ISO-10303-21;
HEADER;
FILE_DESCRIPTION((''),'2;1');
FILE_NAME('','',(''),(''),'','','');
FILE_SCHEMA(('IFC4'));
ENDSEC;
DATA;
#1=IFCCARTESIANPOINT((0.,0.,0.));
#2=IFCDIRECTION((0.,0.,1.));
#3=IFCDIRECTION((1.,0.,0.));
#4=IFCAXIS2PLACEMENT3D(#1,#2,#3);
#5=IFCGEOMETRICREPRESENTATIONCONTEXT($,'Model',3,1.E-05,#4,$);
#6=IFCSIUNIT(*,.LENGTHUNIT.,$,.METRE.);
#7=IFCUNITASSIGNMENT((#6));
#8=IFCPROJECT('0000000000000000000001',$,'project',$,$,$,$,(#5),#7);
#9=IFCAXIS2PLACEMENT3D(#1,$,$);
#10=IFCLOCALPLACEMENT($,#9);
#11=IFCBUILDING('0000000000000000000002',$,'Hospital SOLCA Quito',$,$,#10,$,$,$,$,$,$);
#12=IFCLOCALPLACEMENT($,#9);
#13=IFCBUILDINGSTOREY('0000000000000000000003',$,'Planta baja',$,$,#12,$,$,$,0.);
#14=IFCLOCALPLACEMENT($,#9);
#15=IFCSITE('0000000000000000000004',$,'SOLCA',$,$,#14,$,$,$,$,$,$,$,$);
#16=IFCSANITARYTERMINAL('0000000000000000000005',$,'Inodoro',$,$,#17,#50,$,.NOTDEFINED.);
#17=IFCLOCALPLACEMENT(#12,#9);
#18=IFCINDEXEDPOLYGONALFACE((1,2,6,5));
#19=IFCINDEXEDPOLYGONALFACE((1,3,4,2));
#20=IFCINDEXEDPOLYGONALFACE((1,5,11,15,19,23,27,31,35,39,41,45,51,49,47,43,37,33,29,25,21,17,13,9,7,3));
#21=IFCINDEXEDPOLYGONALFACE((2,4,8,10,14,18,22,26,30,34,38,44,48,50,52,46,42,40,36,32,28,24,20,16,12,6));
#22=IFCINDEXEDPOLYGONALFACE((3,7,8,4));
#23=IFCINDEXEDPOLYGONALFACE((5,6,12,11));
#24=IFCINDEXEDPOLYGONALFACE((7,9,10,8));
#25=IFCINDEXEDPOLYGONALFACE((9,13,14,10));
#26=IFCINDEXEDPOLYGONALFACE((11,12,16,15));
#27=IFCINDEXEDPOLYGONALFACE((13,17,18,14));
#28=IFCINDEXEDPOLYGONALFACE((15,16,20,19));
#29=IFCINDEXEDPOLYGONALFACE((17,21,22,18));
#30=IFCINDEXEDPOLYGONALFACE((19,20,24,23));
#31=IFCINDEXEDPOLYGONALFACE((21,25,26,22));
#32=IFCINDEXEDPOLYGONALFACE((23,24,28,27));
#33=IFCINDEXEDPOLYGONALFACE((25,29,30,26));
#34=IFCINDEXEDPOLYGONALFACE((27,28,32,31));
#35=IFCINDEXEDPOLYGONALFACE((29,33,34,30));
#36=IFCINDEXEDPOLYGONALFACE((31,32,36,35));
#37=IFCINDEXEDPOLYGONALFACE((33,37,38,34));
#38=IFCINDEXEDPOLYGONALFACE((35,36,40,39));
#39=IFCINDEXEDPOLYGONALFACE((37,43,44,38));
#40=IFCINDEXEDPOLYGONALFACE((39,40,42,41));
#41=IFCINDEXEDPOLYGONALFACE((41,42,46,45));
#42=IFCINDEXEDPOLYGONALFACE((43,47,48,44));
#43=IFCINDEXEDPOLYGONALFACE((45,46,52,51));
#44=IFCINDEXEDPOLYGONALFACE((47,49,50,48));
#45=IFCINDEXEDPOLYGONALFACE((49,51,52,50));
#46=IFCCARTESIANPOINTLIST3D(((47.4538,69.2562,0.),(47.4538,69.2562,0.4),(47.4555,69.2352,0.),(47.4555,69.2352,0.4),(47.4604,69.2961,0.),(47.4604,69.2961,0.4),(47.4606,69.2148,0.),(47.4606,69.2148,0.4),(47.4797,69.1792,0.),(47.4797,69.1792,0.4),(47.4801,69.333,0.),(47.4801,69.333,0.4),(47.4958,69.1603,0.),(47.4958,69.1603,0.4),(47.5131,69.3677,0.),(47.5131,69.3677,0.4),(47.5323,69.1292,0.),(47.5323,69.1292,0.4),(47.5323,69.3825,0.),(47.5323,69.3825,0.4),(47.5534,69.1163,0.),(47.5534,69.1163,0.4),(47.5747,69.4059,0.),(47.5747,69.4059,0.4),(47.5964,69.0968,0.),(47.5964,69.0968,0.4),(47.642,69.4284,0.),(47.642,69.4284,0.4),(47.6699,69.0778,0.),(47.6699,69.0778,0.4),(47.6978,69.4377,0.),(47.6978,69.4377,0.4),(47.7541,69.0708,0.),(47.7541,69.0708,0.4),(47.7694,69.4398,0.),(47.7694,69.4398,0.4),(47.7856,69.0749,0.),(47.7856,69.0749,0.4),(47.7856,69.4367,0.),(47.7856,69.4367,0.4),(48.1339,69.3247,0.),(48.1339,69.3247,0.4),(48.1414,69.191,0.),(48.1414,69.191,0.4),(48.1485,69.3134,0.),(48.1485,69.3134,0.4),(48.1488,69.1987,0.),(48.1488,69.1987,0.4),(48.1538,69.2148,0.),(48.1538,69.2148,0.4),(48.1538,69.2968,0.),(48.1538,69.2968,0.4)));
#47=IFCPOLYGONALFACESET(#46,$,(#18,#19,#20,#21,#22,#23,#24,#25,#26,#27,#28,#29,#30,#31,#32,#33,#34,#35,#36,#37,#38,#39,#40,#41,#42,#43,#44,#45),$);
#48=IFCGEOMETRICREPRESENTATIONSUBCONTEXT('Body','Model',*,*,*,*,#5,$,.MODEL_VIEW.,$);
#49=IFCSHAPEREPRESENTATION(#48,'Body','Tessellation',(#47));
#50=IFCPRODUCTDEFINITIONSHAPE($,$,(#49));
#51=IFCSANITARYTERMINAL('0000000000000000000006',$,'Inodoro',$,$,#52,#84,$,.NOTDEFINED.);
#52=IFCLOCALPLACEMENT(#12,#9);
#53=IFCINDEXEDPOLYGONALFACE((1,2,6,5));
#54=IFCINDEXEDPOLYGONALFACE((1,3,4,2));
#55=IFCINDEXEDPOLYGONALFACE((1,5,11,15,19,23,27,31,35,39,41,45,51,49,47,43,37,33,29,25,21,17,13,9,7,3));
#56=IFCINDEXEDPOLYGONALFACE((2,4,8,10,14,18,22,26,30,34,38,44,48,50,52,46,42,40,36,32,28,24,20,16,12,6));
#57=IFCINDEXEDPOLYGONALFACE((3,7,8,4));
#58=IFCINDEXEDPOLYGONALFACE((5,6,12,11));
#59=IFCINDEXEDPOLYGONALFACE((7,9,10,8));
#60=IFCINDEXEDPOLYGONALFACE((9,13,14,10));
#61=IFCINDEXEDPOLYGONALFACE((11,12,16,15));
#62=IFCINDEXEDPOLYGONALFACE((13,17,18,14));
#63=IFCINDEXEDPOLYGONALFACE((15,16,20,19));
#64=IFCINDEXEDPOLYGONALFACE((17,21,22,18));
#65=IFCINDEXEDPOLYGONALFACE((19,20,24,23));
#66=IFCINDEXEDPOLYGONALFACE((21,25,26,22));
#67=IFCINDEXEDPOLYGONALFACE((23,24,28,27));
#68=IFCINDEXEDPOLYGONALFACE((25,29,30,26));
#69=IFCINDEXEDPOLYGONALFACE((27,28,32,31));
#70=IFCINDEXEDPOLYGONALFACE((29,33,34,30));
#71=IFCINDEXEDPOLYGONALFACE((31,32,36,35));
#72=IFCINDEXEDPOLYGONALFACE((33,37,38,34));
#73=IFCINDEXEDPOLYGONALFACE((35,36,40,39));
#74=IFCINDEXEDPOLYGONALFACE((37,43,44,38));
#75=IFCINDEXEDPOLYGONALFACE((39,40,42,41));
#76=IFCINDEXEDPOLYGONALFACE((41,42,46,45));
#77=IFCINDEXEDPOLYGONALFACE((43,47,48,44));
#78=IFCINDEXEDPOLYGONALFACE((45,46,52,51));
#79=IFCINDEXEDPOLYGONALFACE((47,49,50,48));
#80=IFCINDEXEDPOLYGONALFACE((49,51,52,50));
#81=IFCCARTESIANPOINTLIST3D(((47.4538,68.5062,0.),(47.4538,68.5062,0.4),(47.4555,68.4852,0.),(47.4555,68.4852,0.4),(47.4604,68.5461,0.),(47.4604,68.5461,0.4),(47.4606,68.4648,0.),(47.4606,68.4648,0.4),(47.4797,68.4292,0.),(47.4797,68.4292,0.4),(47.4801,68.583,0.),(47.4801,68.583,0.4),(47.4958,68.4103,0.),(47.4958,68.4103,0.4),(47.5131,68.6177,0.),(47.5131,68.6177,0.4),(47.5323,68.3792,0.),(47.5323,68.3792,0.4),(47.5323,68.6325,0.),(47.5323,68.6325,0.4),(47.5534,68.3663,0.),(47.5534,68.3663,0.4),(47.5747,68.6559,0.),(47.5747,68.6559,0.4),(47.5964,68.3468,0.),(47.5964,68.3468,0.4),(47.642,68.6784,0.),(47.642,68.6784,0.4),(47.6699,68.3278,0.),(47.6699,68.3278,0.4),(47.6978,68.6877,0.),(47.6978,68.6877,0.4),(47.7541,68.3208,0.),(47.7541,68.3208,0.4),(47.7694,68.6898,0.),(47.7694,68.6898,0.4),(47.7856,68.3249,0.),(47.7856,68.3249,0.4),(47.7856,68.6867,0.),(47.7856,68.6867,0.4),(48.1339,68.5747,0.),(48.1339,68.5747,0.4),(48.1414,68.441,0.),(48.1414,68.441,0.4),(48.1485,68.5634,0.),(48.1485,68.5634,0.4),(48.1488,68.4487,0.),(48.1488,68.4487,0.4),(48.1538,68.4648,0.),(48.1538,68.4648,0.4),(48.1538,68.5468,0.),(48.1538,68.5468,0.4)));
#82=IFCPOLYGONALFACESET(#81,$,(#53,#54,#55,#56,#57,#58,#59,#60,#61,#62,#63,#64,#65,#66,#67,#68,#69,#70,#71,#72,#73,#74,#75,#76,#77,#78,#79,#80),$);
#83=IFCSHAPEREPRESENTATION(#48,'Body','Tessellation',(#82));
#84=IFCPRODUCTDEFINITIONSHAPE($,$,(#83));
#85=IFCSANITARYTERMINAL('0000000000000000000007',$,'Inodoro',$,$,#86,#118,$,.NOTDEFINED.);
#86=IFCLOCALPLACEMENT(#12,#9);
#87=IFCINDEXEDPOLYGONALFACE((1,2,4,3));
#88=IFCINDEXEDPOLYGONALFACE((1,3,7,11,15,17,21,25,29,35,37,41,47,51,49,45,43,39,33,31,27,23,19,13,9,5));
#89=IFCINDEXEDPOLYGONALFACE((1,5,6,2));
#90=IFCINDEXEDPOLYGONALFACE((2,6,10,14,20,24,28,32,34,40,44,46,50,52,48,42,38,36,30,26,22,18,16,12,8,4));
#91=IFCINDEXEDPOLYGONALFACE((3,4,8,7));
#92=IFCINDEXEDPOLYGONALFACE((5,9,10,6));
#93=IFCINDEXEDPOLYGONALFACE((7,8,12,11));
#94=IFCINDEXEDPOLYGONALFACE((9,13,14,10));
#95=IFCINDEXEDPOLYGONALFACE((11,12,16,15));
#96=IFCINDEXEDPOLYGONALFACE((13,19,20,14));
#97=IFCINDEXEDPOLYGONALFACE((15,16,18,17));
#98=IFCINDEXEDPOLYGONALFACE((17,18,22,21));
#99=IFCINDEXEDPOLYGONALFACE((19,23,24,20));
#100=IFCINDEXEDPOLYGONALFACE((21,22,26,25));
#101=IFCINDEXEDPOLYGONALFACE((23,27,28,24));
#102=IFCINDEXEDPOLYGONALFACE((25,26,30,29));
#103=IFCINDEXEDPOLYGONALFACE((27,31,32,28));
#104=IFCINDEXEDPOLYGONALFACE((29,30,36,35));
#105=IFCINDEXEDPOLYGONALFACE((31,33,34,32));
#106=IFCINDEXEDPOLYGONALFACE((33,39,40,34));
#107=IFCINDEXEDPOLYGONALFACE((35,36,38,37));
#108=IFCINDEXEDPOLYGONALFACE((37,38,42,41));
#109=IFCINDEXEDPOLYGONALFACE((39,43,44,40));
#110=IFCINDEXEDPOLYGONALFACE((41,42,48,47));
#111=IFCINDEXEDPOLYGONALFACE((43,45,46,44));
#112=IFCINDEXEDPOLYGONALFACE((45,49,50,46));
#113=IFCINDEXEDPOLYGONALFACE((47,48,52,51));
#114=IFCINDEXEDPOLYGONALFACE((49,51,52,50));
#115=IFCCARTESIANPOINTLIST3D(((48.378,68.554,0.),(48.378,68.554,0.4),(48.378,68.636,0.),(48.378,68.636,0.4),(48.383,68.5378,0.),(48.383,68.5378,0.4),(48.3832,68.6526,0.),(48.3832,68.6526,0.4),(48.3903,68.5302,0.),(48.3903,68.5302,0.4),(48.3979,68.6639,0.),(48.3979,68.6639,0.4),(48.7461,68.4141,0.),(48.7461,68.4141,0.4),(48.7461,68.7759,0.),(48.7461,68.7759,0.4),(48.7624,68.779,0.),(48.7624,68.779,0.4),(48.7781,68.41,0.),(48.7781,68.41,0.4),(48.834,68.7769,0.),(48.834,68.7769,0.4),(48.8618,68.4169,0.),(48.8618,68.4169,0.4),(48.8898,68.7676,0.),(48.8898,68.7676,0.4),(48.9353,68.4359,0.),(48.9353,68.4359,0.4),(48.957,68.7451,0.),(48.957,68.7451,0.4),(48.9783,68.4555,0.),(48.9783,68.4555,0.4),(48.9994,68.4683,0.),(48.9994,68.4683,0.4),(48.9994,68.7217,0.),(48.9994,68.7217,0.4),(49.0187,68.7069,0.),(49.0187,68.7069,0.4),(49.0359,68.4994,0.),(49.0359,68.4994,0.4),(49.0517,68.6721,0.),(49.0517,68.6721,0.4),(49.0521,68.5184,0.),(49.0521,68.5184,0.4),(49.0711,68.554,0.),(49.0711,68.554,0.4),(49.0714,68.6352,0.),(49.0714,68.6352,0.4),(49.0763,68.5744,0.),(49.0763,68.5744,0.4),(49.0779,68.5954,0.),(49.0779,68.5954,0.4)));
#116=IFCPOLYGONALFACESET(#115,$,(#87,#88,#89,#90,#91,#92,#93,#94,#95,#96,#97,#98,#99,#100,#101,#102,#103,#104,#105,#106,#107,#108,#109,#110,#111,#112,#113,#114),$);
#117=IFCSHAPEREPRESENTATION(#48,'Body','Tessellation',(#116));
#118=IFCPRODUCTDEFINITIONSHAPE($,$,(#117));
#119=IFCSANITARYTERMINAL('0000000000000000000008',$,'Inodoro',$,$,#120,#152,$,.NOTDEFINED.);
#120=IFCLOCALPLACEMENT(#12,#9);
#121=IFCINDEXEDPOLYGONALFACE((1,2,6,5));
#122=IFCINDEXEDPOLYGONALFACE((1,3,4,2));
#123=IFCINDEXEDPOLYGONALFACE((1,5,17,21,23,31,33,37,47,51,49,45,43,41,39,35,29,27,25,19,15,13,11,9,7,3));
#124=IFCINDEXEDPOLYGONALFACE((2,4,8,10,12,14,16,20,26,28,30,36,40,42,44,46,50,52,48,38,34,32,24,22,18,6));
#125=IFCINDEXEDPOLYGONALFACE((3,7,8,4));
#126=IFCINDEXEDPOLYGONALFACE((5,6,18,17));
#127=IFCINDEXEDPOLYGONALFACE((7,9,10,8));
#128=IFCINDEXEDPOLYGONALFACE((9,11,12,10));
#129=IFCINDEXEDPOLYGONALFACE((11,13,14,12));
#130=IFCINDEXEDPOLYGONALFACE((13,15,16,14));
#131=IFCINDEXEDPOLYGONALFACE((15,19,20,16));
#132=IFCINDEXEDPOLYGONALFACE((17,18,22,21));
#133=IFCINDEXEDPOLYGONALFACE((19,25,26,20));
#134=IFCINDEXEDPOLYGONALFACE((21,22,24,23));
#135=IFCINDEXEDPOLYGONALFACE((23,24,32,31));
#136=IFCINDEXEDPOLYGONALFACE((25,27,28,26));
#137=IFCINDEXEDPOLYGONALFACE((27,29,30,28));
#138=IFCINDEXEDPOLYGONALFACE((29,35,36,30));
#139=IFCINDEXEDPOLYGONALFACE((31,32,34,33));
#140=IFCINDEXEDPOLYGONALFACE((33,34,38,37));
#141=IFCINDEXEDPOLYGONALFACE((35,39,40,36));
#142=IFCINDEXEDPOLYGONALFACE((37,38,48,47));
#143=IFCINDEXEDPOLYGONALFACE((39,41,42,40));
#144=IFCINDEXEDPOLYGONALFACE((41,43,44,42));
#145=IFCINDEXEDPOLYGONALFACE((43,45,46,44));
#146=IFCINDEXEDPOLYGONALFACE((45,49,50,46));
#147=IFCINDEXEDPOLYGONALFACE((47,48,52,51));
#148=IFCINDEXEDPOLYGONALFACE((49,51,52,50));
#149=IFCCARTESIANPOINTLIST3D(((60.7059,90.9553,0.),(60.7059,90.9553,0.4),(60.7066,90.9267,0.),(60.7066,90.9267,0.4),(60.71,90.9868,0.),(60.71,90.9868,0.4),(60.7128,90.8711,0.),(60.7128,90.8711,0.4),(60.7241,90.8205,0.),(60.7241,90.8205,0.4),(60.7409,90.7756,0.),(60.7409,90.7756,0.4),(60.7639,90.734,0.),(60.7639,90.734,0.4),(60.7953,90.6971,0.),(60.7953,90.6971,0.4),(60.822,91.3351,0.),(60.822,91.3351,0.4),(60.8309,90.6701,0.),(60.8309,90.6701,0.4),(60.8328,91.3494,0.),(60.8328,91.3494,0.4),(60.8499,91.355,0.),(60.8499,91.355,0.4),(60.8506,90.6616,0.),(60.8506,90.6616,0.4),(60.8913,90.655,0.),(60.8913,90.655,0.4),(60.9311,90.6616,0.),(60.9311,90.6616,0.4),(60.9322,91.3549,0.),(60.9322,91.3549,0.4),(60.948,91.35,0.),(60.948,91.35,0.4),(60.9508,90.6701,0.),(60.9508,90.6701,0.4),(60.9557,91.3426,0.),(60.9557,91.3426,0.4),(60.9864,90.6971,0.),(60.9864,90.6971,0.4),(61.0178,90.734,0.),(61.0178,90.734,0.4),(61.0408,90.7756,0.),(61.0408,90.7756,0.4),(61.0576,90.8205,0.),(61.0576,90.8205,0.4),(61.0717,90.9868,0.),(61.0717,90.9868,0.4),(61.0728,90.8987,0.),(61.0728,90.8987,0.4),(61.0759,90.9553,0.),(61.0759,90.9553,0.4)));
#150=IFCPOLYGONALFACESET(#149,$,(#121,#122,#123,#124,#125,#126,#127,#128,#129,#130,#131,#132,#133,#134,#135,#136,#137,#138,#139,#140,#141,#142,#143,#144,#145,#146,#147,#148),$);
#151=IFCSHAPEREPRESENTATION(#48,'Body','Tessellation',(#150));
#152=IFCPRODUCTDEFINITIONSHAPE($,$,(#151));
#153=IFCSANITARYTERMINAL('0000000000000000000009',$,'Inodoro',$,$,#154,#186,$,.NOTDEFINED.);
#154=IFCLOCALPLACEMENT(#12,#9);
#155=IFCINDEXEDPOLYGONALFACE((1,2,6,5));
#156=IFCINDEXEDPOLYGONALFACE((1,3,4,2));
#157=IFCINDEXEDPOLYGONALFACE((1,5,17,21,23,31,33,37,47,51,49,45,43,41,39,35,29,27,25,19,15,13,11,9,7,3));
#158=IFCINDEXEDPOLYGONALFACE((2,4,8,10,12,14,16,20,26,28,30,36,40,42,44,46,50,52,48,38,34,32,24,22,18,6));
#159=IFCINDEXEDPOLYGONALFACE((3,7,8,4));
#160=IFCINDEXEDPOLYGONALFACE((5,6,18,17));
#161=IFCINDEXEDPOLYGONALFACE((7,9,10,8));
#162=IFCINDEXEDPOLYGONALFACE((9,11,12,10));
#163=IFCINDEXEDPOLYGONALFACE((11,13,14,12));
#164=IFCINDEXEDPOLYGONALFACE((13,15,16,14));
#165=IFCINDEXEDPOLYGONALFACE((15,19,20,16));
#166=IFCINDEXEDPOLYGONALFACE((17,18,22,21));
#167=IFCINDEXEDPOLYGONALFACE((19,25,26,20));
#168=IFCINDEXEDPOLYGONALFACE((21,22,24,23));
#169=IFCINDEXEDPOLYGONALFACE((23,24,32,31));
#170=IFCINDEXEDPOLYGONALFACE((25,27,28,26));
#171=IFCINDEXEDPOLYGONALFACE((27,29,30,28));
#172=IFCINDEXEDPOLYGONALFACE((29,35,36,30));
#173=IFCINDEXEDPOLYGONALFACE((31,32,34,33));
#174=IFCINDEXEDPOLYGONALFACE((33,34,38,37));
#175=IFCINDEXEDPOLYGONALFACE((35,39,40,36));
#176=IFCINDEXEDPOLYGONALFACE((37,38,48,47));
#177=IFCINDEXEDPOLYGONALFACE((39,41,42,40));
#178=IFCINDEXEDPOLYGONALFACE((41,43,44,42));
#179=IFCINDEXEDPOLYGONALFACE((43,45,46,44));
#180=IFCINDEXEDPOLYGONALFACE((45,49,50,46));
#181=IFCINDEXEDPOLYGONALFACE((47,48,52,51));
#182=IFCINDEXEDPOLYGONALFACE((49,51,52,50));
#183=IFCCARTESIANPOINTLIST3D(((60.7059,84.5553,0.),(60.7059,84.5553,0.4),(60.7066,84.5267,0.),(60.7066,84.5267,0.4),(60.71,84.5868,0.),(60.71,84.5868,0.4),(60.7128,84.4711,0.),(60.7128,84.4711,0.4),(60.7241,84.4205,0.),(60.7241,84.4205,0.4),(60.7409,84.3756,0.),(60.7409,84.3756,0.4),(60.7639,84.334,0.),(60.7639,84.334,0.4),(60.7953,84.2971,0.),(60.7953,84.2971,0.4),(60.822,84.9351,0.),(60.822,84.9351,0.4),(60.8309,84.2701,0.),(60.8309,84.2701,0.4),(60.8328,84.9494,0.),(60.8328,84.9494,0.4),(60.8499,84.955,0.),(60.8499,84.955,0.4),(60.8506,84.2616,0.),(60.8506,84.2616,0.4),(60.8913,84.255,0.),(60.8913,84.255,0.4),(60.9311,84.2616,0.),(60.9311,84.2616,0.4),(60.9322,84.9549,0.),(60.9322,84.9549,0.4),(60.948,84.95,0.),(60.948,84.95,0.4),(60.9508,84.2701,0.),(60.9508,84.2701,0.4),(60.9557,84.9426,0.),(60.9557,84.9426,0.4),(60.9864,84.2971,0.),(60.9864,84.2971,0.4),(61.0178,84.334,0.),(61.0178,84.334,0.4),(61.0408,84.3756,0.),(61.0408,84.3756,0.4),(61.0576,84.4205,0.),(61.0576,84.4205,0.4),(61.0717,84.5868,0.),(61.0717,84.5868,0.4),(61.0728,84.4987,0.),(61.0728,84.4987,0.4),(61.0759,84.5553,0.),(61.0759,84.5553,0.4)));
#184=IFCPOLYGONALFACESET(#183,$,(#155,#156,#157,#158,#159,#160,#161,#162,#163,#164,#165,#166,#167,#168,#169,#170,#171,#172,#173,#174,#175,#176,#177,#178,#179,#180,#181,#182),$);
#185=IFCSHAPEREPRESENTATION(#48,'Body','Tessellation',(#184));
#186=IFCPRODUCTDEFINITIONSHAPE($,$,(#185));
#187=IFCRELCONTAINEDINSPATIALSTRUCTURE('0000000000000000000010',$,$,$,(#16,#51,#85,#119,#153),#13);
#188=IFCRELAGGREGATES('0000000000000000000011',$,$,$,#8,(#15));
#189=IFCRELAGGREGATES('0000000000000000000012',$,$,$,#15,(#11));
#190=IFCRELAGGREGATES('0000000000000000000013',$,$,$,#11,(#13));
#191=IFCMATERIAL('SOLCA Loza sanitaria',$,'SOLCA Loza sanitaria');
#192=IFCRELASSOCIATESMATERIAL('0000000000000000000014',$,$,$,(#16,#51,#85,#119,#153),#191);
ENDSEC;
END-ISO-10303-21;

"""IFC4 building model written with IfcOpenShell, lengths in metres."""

from ifc_helpers import new_model, si_unit, origin, origin_with_axes, place, context, subcontext, project, spatial, polyline, outline, extrude, material, element, save


model = new_model("IFC4")

# Units and contexts
model_context = context("Model", 3, precision=1e-05, world=origin_with_axes())
body_context = subcontext(model_context, "Body", "Model", "MODEL_VIEW")
ifc_project = project(units=[si_unit("LENGTHUNIT", "METRE")], contexts=[model_context])

# Site, building, storey
site_placement = place(None, origin())
site = spatial("IfcSite", under=ifc_project, at=site_placement, Name="SOLCA")
building_placement = place(None, origin())
building = spatial("IfcBuilding", under=site, at=building_placement, Name="Hospital SOLCA Quito")
storey_placement = place(None, origin())
storey = spatial("IfcBuildingStorey", under=building, at=storey_placement, Name="Planta baja", Elevation=0.0)

# Sanitary terminals
ifc_material = material(Name="SOLCA Loza sanitaria", Category="SOLCA Loza sanitaria")
sanitary_terminal_1_placement = place(storey_placement, origin_with_axes())
element("IfcSanitaryTerminal", 1, at=sanitary_terminal_1_placement, inside=storey, material=ifc_material, Name="Inodoro", PredefinedType="NOTDEFINED", context=body_context, shape_type="SweptSolid", body=[
    extrude(outline(polyline([(47.7541, 69.0708), (47.6699, 69.0778), (47.5964, 69.0968), (47.5534, 69.1163), (47.5323, 69.1292), (47.4958, 69.1603), (47.4797, 69.1792), (47.4606, 69.2148), (47.4555, 69.2352), (47.4538, 69.2562), (47.4604, 69.2961), (47.4801, 69.333), (47.5131, 69.3677), (47.5323, 69.3825), (47.5747, 69.4059), (47.642, 69.4284), (47.6978, 69.4377), (47.7694, 69.4398), (47.7856, 69.4367), (48.1339, 69.3247), (48.1485, 69.3134), (48.1538, 69.2968), (48.1538, 69.2148), (48.1488, 69.1987), (48.1414, 69.191), (47.7856, 69.0749), (47.7541, 69.0708)])), origin_with_axes(), (0.0, 0.0, 1.0), 0.4),
])
sanitary_terminal_2_placement = place(storey_placement, origin_with_axes())
element("IfcSanitaryTerminal", 2, at=sanitary_terminal_2_placement, inside=storey, material=ifc_material, Name="Inodoro", PredefinedType="NOTDEFINED", context=body_context, shape_type="SweptSolid", body=[
    extrude(outline(polyline([(47.7541, 68.3208), (47.6699, 68.3278), (47.5964, 68.3468), (47.5534, 68.3663), (47.5323, 68.3792), (47.4958, 68.4103), (47.4797, 68.4292), (47.4606, 68.4648), (47.4555, 68.4852), (47.4538, 68.5062), (47.4604, 68.5461), (47.4801, 68.583), (47.5131, 68.6177), (47.5323, 68.6325), (47.5747, 68.6559), (47.642, 68.6784), (47.6978, 68.6877), (47.7694, 68.6898), (47.7856, 68.6867), (48.1339, 68.5747), (48.1485, 68.5634), (48.1538, 68.5468), (48.1538, 68.4648), (48.1488, 68.4487), (48.1414, 68.441), (47.7856, 68.3249), (47.7541, 68.3208)])), origin_with_axes(), (0.0, 0.0, 1.0), 0.4),
])
sanitary_terminal_3_placement = place(storey_placement, origin_with_axes())
element("IfcSanitaryTerminal", 3, at=sanitary_terminal_3_placement, inside=storey, material=ifc_material, Name="Inodoro", PredefinedType="NOTDEFINED", context=body_context, shape_type="SweptSolid", body=[
    extrude(outline(polyline([(48.7781, 68.41), (48.7461, 68.4141), (48.3903, 68.5302), (48.383, 68.5378), (48.378, 68.554), (48.378, 68.636), (48.3832, 68.6526), (48.3979, 68.6639), (48.7461, 68.7759), (48.7624, 68.779), (48.834, 68.7769), (48.8898, 68.7676), (48.957, 68.7451), (48.9994, 68.7217), (49.0187, 68.7069), (49.0517, 68.6721), (49.0714, 68.6352), (49.0779, 68.5954), (49.0763, 68.5744), (49.0711, 68.554), (49.0521, 68.5184), (49.0359, 68.4994), (48.9994, 68.4683), (48.9783, 68.4555), (48.9353, 68.4359), (48.8618, 68.4169), (48.7781, 68.41)])), origin_with_axes(), (0.0, 0.0, 1.0), 0.4),
])
sanitary_terminal_4_placement = place(storey_placement, origin_with_axes())
element("IfcSanitaryTerminal", 4, at=sanitary_terminal_4_placement, inside=storey, material=ifc_material, Name="Inodoro", PredefinedType="NOTDEFINED", context=body_context, shape_type="SweptSolid", body=[
    extrude(outline(polyline([(60.8913, 90.655), (60.8506, 90.6616), (60.8309, 90.6701), (60.7953, 90.6971), (60.7639, 90.734), (60.7409, 90.7756), (60.7241, 90.8205), (60.7128, 90.8711), (60.7066, 90.9267), (60.7059, 90.9553), (60.71, 90.9868), (60.822, 91.3351), (60.8328, 91.3494), (60.8499, 91.355), (60.9322, 91.3549), (60.948, 91.35), (60.9557, 91.3426), (61.0717, 90.9868), (61.0759, 90.9553), (61.0728, 90.8987), (61.0576, 90.8205), (61.0408, 90.7756), (61.0178, 90.734), (60.9864, 90.6971), (60.9508, 90.6701), (60.9311, 90.6616), (60.8913, 90.655)])), origin_with_axes(), (0.0, 0.0, 1.0), 0.4),
])
sanitary_terminal_5_placement = place(storey_placement, origin_with_axes())
element("IfcSanitaryTerminal", 5, at=sanitary_terminal_5_placement, inside=storey, material=ifc_material, Name="Inodoro", PredefinedType="NOTDEFINED", context=body_context, shape_type="SweptSolid", body=[
    extrude(outline(polyline([(60.8913, 84.255), (60.8506, 84.2616), (60.8309, 84.2701), (60.7953, 84.2971), (60.7639, 84.334), (60.7409, 84.3756), (60.7241, 84.4205), (60.7128, 84.4711), (60.7066, 84.5267), (60.7059, 84.5553), (60.71, 84.5868), (60.822, 84.9351), (60.8328, 84.9494), (60.8499, 84.955), (60.9322, 84.9549), (60.948, 84.95), (60.9557, 84.9426), (61.0717, 84.5868), (61.0759, 84.5553), (61.0728, 84.4987), (61.0576, 84.4205), (61.0408, 84.3756), (61.0178, 84.334), (60.9864, 84.2971), (60.9508, 84.2701), (60.9311, 84.2616), (60.8913, 84.255)])), origin_with_axes(), (0.0, 0.0, 1.0), 0.4),
])

save(model, "model.ifc")
